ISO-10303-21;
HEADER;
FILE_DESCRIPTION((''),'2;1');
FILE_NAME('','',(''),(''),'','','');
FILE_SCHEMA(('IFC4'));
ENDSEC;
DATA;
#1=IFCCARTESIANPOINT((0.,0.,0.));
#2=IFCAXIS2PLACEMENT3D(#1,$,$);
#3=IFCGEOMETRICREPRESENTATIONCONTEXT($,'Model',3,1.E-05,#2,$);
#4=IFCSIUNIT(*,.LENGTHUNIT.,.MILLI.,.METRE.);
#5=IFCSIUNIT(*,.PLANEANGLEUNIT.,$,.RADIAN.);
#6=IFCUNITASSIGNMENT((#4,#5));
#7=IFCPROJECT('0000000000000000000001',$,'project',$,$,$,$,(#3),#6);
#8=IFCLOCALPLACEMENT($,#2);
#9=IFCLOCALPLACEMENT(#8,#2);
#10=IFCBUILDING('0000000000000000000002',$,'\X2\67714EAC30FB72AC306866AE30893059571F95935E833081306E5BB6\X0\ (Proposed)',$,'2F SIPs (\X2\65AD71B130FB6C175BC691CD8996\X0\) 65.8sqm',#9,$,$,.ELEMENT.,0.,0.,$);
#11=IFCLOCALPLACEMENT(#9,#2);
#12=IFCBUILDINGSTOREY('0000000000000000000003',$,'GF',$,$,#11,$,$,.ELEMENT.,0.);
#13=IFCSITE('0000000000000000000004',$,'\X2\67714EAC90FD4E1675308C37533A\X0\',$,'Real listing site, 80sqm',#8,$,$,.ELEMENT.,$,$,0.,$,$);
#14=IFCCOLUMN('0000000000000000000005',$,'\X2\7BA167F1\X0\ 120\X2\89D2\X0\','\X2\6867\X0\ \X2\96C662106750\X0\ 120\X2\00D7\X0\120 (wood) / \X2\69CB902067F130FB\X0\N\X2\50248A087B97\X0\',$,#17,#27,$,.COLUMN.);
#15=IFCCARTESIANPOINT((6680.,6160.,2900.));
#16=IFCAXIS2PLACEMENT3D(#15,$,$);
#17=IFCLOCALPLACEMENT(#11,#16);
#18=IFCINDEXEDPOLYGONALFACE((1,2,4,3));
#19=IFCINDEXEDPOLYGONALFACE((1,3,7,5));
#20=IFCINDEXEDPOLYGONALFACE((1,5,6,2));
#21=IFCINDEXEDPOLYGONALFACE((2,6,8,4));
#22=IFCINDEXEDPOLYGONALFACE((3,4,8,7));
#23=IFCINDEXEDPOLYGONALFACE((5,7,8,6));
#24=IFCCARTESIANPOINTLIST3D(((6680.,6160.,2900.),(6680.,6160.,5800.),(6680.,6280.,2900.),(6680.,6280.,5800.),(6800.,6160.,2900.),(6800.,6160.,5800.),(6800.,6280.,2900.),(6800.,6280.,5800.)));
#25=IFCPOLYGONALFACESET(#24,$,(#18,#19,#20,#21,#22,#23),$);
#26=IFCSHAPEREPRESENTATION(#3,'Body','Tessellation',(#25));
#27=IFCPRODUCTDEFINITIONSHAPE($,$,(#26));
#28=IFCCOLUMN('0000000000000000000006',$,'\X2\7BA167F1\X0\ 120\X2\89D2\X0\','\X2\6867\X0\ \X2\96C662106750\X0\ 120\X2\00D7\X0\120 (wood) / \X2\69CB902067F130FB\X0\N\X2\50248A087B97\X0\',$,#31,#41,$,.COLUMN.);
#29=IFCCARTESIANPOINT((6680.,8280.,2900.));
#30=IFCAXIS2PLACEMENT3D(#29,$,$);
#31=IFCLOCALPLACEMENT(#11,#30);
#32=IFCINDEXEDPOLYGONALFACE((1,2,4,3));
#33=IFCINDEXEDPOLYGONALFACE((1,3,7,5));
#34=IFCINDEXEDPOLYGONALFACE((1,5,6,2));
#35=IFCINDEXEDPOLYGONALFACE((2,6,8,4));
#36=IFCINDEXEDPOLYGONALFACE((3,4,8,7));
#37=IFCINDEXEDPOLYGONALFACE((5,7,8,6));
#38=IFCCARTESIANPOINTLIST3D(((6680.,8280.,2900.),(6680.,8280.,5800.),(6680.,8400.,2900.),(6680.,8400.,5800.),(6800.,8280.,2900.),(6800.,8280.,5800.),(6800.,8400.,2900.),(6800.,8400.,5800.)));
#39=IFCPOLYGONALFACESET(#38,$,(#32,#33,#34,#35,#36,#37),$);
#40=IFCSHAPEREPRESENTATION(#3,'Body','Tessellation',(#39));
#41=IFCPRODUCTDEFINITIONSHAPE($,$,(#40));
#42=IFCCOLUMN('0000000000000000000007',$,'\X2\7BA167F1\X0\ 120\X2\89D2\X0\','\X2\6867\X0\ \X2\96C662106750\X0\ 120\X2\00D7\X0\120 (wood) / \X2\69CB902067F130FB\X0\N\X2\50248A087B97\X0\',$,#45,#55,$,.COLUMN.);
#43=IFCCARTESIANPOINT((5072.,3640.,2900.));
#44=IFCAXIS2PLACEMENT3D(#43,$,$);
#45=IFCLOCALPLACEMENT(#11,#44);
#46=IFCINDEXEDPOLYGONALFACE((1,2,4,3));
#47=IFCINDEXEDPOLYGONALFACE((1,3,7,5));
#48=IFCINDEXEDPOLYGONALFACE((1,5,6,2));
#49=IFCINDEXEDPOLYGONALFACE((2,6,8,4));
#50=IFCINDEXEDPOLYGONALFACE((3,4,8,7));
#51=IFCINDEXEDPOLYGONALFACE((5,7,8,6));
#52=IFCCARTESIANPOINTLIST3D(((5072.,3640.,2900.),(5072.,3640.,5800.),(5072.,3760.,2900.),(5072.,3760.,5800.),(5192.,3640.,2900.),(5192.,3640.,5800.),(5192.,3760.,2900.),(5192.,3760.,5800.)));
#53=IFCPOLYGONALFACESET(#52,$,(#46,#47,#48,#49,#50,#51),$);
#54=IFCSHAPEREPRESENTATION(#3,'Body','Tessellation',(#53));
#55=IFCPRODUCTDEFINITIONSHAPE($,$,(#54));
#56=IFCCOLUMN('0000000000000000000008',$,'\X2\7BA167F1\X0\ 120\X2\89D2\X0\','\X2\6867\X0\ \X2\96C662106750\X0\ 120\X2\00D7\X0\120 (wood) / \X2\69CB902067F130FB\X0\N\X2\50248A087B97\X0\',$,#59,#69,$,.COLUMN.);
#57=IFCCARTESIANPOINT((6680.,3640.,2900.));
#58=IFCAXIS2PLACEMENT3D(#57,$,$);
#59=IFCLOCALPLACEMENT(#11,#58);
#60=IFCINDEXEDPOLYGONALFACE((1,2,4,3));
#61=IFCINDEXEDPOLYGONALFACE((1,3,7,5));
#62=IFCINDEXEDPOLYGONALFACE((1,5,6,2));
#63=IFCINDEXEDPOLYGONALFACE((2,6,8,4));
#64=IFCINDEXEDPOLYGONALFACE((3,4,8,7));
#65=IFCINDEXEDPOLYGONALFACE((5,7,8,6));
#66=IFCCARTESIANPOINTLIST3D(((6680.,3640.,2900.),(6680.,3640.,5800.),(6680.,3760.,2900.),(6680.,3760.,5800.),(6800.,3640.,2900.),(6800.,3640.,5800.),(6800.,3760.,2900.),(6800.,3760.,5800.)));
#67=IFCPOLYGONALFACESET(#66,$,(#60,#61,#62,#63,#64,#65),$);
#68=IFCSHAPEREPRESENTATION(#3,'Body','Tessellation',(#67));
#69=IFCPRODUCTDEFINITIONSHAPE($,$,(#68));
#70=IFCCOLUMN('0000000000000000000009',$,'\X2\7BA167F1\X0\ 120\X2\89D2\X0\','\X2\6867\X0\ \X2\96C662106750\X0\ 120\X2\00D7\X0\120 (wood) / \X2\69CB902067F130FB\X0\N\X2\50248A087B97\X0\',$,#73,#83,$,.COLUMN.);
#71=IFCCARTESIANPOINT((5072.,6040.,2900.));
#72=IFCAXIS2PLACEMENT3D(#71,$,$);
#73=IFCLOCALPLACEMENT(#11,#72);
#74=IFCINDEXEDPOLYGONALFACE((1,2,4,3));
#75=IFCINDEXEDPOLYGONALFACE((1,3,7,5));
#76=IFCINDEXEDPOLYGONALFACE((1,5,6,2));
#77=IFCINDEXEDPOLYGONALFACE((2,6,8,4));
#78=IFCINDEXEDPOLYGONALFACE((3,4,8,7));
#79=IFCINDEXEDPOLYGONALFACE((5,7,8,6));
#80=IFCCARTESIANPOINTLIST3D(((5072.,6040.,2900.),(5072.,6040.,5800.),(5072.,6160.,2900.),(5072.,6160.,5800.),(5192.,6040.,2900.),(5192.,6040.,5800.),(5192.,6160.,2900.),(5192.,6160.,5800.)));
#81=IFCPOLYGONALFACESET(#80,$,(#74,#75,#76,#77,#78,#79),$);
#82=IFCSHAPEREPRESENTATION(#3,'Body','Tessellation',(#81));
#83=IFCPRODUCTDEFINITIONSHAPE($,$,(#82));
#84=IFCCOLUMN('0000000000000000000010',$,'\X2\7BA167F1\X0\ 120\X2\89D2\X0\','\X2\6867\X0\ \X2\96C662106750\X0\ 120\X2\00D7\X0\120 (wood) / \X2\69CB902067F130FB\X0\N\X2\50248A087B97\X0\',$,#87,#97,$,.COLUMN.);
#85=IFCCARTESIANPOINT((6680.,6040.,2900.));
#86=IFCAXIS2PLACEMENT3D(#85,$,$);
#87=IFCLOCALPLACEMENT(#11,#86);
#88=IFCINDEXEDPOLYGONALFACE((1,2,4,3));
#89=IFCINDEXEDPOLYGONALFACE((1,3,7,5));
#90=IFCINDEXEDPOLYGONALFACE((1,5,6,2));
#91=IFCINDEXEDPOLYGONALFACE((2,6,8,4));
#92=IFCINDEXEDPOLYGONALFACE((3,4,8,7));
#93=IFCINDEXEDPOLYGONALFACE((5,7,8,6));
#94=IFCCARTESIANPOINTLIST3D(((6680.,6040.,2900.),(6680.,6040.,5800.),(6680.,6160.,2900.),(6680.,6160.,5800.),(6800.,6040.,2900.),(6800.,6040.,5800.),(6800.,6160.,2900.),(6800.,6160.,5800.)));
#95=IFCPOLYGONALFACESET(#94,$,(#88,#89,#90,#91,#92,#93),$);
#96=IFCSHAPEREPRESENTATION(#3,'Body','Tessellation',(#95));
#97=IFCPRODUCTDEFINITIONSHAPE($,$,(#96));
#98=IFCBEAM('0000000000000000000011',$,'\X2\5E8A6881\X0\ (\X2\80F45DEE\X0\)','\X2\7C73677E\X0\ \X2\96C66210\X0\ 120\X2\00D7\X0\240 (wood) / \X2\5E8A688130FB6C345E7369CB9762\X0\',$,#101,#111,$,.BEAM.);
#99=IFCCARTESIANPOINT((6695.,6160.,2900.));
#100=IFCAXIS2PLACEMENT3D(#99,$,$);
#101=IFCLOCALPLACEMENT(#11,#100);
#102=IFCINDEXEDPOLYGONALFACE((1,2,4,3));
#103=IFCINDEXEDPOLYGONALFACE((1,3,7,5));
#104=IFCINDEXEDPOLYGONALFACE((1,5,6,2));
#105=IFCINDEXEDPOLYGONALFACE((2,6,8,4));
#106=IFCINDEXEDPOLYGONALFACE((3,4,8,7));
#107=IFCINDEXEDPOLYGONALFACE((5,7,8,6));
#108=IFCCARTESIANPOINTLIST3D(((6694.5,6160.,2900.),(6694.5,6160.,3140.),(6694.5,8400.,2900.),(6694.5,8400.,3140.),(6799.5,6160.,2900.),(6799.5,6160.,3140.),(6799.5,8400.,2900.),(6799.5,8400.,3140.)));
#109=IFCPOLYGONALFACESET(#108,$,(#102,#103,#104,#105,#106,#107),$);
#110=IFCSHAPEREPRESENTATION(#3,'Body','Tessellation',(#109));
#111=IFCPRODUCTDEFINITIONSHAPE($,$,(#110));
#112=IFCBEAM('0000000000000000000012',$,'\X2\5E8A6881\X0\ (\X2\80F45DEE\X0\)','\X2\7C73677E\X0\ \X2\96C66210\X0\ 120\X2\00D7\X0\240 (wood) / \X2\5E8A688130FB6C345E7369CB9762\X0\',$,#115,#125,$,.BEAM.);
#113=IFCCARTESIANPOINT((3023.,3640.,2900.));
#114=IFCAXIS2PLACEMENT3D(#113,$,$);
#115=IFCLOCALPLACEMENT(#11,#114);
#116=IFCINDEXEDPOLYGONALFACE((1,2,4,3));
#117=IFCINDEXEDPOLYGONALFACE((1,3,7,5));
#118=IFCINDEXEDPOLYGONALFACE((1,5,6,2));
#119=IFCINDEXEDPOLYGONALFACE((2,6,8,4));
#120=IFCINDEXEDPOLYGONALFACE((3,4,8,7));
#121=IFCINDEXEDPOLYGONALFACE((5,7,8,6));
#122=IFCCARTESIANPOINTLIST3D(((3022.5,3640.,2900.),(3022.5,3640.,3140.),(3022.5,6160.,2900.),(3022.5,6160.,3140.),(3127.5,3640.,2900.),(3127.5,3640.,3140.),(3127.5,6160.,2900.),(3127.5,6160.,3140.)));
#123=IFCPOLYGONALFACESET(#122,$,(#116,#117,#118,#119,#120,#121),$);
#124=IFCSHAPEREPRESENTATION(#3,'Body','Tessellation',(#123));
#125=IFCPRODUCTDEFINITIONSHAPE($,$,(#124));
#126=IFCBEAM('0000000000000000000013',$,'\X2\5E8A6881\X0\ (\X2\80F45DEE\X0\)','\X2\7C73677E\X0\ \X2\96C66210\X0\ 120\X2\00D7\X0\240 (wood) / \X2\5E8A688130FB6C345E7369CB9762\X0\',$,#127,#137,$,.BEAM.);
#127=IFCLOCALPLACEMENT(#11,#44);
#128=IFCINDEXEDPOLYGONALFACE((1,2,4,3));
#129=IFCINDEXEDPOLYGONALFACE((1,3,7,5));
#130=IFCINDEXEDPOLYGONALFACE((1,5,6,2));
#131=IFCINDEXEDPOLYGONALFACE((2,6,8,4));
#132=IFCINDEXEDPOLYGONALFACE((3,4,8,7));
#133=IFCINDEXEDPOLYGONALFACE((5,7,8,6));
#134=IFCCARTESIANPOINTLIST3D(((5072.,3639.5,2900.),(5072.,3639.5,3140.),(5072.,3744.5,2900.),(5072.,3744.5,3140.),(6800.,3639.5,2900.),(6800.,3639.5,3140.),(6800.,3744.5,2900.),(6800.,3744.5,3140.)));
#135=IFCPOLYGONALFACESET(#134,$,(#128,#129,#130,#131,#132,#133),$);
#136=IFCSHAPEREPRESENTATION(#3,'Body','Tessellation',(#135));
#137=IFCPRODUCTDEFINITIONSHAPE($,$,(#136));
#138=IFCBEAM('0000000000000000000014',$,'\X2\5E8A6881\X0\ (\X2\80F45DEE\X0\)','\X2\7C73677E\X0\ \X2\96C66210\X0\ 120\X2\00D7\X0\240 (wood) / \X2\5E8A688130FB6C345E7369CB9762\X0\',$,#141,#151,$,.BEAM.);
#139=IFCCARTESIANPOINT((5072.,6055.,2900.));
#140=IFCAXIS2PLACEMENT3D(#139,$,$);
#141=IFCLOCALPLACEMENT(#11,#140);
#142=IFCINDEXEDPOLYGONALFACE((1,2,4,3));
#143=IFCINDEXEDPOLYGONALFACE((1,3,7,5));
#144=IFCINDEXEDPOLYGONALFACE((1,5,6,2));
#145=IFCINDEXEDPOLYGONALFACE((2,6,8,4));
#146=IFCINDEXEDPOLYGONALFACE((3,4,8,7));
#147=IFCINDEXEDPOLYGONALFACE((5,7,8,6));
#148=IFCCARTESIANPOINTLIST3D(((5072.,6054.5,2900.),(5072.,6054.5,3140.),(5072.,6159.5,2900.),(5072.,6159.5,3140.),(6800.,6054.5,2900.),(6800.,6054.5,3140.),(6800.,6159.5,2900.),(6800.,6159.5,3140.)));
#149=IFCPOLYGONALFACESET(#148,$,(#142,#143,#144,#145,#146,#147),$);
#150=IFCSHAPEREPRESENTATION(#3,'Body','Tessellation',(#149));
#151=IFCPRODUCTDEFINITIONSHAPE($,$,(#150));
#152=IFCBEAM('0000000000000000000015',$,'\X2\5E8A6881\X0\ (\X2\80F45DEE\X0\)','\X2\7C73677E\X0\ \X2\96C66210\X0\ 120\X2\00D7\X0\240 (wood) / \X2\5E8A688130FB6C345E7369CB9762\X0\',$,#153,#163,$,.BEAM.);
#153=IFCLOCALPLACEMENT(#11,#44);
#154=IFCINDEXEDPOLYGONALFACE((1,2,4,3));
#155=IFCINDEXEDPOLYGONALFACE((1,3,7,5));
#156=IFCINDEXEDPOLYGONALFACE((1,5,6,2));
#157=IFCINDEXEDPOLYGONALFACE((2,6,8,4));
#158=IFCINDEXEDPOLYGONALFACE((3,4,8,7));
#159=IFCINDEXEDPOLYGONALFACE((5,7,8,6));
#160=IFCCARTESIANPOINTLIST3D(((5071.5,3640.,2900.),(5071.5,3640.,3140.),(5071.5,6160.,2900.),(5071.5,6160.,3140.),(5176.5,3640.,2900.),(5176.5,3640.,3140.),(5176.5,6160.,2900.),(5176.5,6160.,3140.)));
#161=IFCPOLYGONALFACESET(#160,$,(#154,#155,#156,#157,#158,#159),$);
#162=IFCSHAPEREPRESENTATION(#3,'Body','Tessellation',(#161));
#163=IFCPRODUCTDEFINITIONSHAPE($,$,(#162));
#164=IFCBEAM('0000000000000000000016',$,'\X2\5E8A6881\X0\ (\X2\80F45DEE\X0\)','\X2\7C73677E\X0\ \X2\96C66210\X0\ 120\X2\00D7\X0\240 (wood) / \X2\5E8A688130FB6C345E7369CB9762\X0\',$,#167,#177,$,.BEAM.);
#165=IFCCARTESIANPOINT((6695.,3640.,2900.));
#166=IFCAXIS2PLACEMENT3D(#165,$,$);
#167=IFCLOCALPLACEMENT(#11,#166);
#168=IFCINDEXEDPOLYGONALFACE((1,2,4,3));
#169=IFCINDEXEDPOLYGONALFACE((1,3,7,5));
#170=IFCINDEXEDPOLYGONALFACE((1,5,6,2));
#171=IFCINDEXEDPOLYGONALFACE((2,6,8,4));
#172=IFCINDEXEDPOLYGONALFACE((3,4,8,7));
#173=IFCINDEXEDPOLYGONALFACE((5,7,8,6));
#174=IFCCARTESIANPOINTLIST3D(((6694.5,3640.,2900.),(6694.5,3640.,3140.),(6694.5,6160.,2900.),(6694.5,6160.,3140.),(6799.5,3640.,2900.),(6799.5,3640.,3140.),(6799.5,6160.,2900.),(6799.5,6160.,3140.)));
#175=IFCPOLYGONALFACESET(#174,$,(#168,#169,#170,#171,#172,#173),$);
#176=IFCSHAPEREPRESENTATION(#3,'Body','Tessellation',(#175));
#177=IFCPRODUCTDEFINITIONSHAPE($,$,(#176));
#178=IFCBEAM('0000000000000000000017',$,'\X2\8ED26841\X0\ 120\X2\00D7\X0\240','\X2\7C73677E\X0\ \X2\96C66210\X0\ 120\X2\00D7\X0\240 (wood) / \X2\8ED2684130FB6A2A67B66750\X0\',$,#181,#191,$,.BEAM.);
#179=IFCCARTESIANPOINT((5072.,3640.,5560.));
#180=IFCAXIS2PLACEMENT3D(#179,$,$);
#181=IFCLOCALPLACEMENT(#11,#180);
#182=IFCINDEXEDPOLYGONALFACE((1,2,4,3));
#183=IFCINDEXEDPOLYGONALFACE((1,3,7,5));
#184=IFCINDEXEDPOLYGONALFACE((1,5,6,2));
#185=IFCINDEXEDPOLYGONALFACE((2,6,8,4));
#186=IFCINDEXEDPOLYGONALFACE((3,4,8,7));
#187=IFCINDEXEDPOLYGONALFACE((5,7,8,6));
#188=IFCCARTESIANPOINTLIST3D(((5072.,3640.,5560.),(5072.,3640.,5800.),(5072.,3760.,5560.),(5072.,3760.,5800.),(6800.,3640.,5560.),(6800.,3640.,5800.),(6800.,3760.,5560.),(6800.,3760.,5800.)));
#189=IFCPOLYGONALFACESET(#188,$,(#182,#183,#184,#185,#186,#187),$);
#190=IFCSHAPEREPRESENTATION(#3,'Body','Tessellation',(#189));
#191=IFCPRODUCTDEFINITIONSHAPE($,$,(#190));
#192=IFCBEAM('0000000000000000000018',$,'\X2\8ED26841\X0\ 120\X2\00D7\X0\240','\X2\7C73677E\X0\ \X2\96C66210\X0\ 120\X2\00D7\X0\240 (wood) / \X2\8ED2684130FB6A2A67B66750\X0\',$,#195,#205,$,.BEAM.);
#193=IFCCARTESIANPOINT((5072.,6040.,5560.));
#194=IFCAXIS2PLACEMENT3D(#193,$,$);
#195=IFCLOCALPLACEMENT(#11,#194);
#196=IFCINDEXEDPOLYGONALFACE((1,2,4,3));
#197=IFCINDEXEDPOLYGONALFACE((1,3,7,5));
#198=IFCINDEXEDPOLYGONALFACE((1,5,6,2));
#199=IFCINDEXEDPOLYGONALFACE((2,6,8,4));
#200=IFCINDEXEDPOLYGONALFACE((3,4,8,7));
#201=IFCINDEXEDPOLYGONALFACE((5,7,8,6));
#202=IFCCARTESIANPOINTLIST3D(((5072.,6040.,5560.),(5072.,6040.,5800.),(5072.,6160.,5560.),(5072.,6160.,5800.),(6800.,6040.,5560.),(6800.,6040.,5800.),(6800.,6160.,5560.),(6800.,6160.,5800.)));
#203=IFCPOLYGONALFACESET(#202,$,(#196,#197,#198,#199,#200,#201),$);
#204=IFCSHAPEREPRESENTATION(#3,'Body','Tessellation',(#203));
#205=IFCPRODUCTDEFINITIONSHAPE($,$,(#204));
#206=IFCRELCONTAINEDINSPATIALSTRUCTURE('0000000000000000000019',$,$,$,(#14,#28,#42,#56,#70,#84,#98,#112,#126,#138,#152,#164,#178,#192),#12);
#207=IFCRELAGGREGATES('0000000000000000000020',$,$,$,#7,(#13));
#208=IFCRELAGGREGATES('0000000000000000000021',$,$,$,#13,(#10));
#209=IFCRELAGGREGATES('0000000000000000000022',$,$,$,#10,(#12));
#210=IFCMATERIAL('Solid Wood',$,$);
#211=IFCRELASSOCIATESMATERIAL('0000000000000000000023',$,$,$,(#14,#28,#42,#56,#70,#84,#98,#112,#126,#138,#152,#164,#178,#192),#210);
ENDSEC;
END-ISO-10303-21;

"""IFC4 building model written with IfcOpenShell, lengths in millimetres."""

from ifc_helpers import new_model, si_unit, frame, frame_2d, origin, place, context, project, spatial, rectangle, extrude, material, element, save


model = new_model("IFC4")

# Units and contexts
model_context = context("Model", 3, precision=1e-05, world=origin())
ifc_project = project(units=[si_unit("LENGTHUNIT", "METRE", prefix="MILLI"), si_unit("PLANEANGLEUNIT", "RADIAN")], contexts=[model_context])

# Site, building, storey
site_placement = place(None, origin())
site = spatial("IfcSite", under=ifc_project, at=site_placement, Name="東京都世田谷区", ObjectType="Real listing site, 80sqm", CompositionType="ELEMENT", RefElevation=0.0)
building_placement = place(site_placement, origin())
building = spatial("IfcBuilding", under=site, at=building_placement, Name="東京・犬と暮らす土間広めの家 (Proposed)", ObjectType="2F SIPs (断熱・気密重視) 65.8sqm", CompositionType="ELEMENT", ElevationOfRefHeight=0.0, ElevationOfTerrain=0.0)
storey_placement = place(building_placement, origin())
storey = spatial("IfcBuildingStorey", under=building, at=storey_placement, Name="GF", CompositionType="ELEMENT", Elevation=0.0)

# Columns
ifc_material_1 = material(Name="Solid Wood")
column_1_placement = place(storey_placement, frame((6680.0, 6160.0, 2900.0)))
element("IfcColumn", 1, at=column_1_placement, inside=storey, material=ifc_material_1, Name="管柱 120角", Description="桧 集成材 120×120 (wood) / 構造柱・N値計算", PredefinedType="COLUMN", context=model_context, shape_type="SweptSolid", body=[
    extrude(rectangle(XDim=120.0, YDim=120.0, at=frame_2d((60.0, 60.0))), frame((6680.0, 6160.0, 2900.0)), (0.0, 0.0, 1.0), 2900.0),
])
column_2_placement = place(storey_placement, frame((6680.0, 8280.0, 2900.0)))
element("IfcColumn", 2, at=column_2_placement, inside=storey, material=ifc_material_1, Name="管柱 120角", Description="桧 集成材 120×120 (wood) / 構造柱・N値計算", PredefinedType="COLUMN", context=model_context, shape_type="SweptSolid", body=[
    extrude(rectangle(XDim=120.0, YDim=120.0, at=frame_2d((60.0, 60.0))), frame((6680.0, 8280.0, 2900.0)), (0.0, 0.0, 1.0), 2900.0),
])
column_3_placement = place(storey_placement, frame((5072.0, 3640.0, 2900.0)))
element("IfcColumn", 3, at=column_3_placement, inside=storey, material=ifc_material_1, Name="管柱 120角", Description="桧 集成材 120×120 (wood) / 構造柱・N値計算", PredefinedType="COLUMN", context=model_context, shape_type="SweptSolid", body=[
    extrude(rectangle(XDim=120.0, YDim=120.0, at=frame_2d((60.0, 60.0))), frame((5072.0, 3640.0, 2900.0)), (0.0, 0.0, 1.0), 2900.0),
])
column_4_placement = place(storey_placement, frame((6680.0, 3640.0, 2900.0)))
element("IfcColumn", 4, at=column_4_placement, inside=storey, material=ifc_material_1, Name="管柱 120角", Description="桧 集成材 120×120 (wood) / 構造柱・N値計算", PredefinedType="COLUMN", context=model_context, shape_type="SweptSolid", body=[
    extrude(rectangle(XDim=120.0, YDim=120.0, at=frame_2d((60.0, 60.0))), frame((6680.0, 3640.0, 2900.0)), (0.0, 0.0, 1.0), 2900.0),
])
column_5_placement = place(storey_placement, frame((5072.0, 6040.0, 2900.0)))
element("IfcColumn", 5, at=column_5_placement, inside=storey, material=ifc_material_1, Name="管柱 120角", Description="桧 集成材 120×120 (wood) / 構造柱・N値計算", PredefinedType="COLUMN", context=model_context, shape_type="SweptSolid", body=[
    extrude(rectangle(XDim=120.0, YDim=120.0, at=frame_2d((60.0, 60.0))), frame((5072.0, 6040.0, 2900.0)), (0.0, 0.0, 1.0), 2900.0),
])
column_6_placement = place(storey_placement, frame((6680.0, 6040.0, 2900.0)))
element("IfcColumn", 6, at=column_6_placement, inside=storey, material=ifc_material_1, Name="管柱 120角", Description="桧 集成材 120×120 (wood) / 構造柱・N値計算", PredefinedType="COLUMN", context=model_context, shape_type="SweptSolid", body=[
    extrude(rectangle(XDim=120.0, YDim=120.0, at=frame_2d((60.0, 60.0))), frame((6680.0, 6040.0, 2900.0)), (0.0, 0.0, 1.0), 2900.0),
])

# Beams
beam_1_placement = place(storey_placement, frame((6695.0, 6160.0, 2900.0)))
element("IfcBeam", 7, at=beam_1_placement, inside=storey, material=ifc_material_1, Name="床梁 (胴差)", Description="米松 集成 120×240 (wood) / 床梁・水平構面", PredefinedType="BEAM", context=model_context, shape_type="SweptSolid", body=[
    extrude(rectangle(XDim=105.0, YDim=2240.0, at=frame_2d((52.0, 1120.0))), frame((6695.0, 6160.0, 2900.0)), (0.0, 0.0, 1.0), 240.0),
])
beam_2_placement = place(storey_placement, frame((3023.0, 3640.0, 2900.0)))
element("IfcBeam", 8, at=beam_2_placement, inside=storey, material=ifc_material_1, Name="床梁 (胴差)", Description="米松 集成 120×240 (wood) / 床梁・水平構面", PredefinedType="BEAM", context=model_context, shape_type="SweptSolid", body=[
    extrude(rectangle(XDim=105.0, YDim=2520.0, at=frame_2d((52.0, 1260.0))), frame((3023.0, 3640.0, 2900.0)), (0.0, 0.0, 1.0), 240.0),
])
beam_3_placement = place(storey_placement, frame((5072.0, 3640.0, 2900.0)))
element("IfcBeam", 9, at=beam_3_placement, inside=storey, material=ifc_material_1, Name="床梁 (胴差)", Description="米松 集成 120×240 (wood) / 床梁・水平構面", PredefinedType="BEAM", context=model_context, shape_type="SweptSolid", body=[
    extrude(rectangle(XDim=1728.0, YDim=105.0, at=frame_2d((864.0, 52.0))), frame((5072.0, 3640.0, 2900.0)), (0.0, 0.0, 1.0), 240.0),
])
beam_4_placement = place(storey_placement, frame((5072.0, 6055.0, 2900.0)))
element("IfcBeam", 10, at=beam_4_placement, inside=storey, material=ifc_material_1, Name="床梁 (胴差)", Description="米松 集成 120×240 (wood) / 床梁・水平構面", PredefinedType="BEAM", context=model_context, shape_type="SweptSolid", body=[
    extrude(rectangle(XDim=1728.0, YDim=105.0, at=frame_2d((864.0, 52.0))), frame((5072.0, 6055.0, 2900.0)), (0.0, 0.0, 1.0), 240.0),
])
beam_5_placement = place(storey_placement, frame((5072.0, 3640.0, 2900.0)))
element("IfcBeam", 11, at=beam_5_placement, inside=storey, material=ifc_material_1, Name="床梁 (胴差)", Description="米松 集成 120×240 (wood) / 床梁・水平構面", PredefinedType="BEAM", context=model_context, shape_type="SweptSolid", body=[
    extrude(rectangle(XDim=105.0, YDim=2520.0, at=frame_2d((52.0, 1260.0))), frame((5072.0, 3640.0, 2900.0)), (0.0, 0.0, 1.0), 240.0),
])
beam_6_placement = place(storey_placement, frame((6695.0, 3640.0, 2900.0)))
element("IfcBeam", 12, at=beam_6_placement, inside=storey, material=ifc_material_1, Name="床梁 (胴差)", Description="米松 集成 120×240 (wood) / 床梁・水平構面", PredefinedType="BEAM", context=model_context, shape_type="SweptSolid", body=[
    extrude(rectangle(XDim=105.0, YDim=2520.0, at=frame_2d((52.0, 1260.0))), frame((6695.0, 3640.0, 2900.0)), (0.0, 0.0, 1.0), 240.0),
])
beam_7_placement = place(storey_placement, frame((5072.0, 3640.0, 5560.0)))
element("IfcBeam", 13, at=beam_7_placement, inside=storey, material=ifc_material_1, Name="軒桁 120×240", Description="米松 集成 120×240 (wood) / 軒桁・横架材", PredefinedType="BEAM", context=model_context, shape_type="SweptSolid", body=[
    extrude(rectangle(XDim=1728.0, YDim=120.0, at=frame_2d((864.0, 60.0))), frame((5072.0, 3640.0, 5560.0)), (0.0, 0.0, 1.0), 240.0),
])
beam_8_placement = place(storey_placement, frame((5072.0, 6040.0, 5560.0)))
element("IfcBeam", 14, at=beam_8_placement, inside=storey, material=ifc_material_1, Name="軒桁 120×240", Description="米松 集成 120×240 (wood) / 軒桁・横架材", PredefinedType="BEAM", context=model_context, shape_type="SweptSolid", body=[
    extrude(rectangle(XDim=1728.0, YDim=120.0, at=frame_2d((864.0, 60.0))), frame((5072.0, 6040.0, 5560.0)), (0.0, 0.0, 1.0), 240.0),
])

save(model, "model.ifc")
